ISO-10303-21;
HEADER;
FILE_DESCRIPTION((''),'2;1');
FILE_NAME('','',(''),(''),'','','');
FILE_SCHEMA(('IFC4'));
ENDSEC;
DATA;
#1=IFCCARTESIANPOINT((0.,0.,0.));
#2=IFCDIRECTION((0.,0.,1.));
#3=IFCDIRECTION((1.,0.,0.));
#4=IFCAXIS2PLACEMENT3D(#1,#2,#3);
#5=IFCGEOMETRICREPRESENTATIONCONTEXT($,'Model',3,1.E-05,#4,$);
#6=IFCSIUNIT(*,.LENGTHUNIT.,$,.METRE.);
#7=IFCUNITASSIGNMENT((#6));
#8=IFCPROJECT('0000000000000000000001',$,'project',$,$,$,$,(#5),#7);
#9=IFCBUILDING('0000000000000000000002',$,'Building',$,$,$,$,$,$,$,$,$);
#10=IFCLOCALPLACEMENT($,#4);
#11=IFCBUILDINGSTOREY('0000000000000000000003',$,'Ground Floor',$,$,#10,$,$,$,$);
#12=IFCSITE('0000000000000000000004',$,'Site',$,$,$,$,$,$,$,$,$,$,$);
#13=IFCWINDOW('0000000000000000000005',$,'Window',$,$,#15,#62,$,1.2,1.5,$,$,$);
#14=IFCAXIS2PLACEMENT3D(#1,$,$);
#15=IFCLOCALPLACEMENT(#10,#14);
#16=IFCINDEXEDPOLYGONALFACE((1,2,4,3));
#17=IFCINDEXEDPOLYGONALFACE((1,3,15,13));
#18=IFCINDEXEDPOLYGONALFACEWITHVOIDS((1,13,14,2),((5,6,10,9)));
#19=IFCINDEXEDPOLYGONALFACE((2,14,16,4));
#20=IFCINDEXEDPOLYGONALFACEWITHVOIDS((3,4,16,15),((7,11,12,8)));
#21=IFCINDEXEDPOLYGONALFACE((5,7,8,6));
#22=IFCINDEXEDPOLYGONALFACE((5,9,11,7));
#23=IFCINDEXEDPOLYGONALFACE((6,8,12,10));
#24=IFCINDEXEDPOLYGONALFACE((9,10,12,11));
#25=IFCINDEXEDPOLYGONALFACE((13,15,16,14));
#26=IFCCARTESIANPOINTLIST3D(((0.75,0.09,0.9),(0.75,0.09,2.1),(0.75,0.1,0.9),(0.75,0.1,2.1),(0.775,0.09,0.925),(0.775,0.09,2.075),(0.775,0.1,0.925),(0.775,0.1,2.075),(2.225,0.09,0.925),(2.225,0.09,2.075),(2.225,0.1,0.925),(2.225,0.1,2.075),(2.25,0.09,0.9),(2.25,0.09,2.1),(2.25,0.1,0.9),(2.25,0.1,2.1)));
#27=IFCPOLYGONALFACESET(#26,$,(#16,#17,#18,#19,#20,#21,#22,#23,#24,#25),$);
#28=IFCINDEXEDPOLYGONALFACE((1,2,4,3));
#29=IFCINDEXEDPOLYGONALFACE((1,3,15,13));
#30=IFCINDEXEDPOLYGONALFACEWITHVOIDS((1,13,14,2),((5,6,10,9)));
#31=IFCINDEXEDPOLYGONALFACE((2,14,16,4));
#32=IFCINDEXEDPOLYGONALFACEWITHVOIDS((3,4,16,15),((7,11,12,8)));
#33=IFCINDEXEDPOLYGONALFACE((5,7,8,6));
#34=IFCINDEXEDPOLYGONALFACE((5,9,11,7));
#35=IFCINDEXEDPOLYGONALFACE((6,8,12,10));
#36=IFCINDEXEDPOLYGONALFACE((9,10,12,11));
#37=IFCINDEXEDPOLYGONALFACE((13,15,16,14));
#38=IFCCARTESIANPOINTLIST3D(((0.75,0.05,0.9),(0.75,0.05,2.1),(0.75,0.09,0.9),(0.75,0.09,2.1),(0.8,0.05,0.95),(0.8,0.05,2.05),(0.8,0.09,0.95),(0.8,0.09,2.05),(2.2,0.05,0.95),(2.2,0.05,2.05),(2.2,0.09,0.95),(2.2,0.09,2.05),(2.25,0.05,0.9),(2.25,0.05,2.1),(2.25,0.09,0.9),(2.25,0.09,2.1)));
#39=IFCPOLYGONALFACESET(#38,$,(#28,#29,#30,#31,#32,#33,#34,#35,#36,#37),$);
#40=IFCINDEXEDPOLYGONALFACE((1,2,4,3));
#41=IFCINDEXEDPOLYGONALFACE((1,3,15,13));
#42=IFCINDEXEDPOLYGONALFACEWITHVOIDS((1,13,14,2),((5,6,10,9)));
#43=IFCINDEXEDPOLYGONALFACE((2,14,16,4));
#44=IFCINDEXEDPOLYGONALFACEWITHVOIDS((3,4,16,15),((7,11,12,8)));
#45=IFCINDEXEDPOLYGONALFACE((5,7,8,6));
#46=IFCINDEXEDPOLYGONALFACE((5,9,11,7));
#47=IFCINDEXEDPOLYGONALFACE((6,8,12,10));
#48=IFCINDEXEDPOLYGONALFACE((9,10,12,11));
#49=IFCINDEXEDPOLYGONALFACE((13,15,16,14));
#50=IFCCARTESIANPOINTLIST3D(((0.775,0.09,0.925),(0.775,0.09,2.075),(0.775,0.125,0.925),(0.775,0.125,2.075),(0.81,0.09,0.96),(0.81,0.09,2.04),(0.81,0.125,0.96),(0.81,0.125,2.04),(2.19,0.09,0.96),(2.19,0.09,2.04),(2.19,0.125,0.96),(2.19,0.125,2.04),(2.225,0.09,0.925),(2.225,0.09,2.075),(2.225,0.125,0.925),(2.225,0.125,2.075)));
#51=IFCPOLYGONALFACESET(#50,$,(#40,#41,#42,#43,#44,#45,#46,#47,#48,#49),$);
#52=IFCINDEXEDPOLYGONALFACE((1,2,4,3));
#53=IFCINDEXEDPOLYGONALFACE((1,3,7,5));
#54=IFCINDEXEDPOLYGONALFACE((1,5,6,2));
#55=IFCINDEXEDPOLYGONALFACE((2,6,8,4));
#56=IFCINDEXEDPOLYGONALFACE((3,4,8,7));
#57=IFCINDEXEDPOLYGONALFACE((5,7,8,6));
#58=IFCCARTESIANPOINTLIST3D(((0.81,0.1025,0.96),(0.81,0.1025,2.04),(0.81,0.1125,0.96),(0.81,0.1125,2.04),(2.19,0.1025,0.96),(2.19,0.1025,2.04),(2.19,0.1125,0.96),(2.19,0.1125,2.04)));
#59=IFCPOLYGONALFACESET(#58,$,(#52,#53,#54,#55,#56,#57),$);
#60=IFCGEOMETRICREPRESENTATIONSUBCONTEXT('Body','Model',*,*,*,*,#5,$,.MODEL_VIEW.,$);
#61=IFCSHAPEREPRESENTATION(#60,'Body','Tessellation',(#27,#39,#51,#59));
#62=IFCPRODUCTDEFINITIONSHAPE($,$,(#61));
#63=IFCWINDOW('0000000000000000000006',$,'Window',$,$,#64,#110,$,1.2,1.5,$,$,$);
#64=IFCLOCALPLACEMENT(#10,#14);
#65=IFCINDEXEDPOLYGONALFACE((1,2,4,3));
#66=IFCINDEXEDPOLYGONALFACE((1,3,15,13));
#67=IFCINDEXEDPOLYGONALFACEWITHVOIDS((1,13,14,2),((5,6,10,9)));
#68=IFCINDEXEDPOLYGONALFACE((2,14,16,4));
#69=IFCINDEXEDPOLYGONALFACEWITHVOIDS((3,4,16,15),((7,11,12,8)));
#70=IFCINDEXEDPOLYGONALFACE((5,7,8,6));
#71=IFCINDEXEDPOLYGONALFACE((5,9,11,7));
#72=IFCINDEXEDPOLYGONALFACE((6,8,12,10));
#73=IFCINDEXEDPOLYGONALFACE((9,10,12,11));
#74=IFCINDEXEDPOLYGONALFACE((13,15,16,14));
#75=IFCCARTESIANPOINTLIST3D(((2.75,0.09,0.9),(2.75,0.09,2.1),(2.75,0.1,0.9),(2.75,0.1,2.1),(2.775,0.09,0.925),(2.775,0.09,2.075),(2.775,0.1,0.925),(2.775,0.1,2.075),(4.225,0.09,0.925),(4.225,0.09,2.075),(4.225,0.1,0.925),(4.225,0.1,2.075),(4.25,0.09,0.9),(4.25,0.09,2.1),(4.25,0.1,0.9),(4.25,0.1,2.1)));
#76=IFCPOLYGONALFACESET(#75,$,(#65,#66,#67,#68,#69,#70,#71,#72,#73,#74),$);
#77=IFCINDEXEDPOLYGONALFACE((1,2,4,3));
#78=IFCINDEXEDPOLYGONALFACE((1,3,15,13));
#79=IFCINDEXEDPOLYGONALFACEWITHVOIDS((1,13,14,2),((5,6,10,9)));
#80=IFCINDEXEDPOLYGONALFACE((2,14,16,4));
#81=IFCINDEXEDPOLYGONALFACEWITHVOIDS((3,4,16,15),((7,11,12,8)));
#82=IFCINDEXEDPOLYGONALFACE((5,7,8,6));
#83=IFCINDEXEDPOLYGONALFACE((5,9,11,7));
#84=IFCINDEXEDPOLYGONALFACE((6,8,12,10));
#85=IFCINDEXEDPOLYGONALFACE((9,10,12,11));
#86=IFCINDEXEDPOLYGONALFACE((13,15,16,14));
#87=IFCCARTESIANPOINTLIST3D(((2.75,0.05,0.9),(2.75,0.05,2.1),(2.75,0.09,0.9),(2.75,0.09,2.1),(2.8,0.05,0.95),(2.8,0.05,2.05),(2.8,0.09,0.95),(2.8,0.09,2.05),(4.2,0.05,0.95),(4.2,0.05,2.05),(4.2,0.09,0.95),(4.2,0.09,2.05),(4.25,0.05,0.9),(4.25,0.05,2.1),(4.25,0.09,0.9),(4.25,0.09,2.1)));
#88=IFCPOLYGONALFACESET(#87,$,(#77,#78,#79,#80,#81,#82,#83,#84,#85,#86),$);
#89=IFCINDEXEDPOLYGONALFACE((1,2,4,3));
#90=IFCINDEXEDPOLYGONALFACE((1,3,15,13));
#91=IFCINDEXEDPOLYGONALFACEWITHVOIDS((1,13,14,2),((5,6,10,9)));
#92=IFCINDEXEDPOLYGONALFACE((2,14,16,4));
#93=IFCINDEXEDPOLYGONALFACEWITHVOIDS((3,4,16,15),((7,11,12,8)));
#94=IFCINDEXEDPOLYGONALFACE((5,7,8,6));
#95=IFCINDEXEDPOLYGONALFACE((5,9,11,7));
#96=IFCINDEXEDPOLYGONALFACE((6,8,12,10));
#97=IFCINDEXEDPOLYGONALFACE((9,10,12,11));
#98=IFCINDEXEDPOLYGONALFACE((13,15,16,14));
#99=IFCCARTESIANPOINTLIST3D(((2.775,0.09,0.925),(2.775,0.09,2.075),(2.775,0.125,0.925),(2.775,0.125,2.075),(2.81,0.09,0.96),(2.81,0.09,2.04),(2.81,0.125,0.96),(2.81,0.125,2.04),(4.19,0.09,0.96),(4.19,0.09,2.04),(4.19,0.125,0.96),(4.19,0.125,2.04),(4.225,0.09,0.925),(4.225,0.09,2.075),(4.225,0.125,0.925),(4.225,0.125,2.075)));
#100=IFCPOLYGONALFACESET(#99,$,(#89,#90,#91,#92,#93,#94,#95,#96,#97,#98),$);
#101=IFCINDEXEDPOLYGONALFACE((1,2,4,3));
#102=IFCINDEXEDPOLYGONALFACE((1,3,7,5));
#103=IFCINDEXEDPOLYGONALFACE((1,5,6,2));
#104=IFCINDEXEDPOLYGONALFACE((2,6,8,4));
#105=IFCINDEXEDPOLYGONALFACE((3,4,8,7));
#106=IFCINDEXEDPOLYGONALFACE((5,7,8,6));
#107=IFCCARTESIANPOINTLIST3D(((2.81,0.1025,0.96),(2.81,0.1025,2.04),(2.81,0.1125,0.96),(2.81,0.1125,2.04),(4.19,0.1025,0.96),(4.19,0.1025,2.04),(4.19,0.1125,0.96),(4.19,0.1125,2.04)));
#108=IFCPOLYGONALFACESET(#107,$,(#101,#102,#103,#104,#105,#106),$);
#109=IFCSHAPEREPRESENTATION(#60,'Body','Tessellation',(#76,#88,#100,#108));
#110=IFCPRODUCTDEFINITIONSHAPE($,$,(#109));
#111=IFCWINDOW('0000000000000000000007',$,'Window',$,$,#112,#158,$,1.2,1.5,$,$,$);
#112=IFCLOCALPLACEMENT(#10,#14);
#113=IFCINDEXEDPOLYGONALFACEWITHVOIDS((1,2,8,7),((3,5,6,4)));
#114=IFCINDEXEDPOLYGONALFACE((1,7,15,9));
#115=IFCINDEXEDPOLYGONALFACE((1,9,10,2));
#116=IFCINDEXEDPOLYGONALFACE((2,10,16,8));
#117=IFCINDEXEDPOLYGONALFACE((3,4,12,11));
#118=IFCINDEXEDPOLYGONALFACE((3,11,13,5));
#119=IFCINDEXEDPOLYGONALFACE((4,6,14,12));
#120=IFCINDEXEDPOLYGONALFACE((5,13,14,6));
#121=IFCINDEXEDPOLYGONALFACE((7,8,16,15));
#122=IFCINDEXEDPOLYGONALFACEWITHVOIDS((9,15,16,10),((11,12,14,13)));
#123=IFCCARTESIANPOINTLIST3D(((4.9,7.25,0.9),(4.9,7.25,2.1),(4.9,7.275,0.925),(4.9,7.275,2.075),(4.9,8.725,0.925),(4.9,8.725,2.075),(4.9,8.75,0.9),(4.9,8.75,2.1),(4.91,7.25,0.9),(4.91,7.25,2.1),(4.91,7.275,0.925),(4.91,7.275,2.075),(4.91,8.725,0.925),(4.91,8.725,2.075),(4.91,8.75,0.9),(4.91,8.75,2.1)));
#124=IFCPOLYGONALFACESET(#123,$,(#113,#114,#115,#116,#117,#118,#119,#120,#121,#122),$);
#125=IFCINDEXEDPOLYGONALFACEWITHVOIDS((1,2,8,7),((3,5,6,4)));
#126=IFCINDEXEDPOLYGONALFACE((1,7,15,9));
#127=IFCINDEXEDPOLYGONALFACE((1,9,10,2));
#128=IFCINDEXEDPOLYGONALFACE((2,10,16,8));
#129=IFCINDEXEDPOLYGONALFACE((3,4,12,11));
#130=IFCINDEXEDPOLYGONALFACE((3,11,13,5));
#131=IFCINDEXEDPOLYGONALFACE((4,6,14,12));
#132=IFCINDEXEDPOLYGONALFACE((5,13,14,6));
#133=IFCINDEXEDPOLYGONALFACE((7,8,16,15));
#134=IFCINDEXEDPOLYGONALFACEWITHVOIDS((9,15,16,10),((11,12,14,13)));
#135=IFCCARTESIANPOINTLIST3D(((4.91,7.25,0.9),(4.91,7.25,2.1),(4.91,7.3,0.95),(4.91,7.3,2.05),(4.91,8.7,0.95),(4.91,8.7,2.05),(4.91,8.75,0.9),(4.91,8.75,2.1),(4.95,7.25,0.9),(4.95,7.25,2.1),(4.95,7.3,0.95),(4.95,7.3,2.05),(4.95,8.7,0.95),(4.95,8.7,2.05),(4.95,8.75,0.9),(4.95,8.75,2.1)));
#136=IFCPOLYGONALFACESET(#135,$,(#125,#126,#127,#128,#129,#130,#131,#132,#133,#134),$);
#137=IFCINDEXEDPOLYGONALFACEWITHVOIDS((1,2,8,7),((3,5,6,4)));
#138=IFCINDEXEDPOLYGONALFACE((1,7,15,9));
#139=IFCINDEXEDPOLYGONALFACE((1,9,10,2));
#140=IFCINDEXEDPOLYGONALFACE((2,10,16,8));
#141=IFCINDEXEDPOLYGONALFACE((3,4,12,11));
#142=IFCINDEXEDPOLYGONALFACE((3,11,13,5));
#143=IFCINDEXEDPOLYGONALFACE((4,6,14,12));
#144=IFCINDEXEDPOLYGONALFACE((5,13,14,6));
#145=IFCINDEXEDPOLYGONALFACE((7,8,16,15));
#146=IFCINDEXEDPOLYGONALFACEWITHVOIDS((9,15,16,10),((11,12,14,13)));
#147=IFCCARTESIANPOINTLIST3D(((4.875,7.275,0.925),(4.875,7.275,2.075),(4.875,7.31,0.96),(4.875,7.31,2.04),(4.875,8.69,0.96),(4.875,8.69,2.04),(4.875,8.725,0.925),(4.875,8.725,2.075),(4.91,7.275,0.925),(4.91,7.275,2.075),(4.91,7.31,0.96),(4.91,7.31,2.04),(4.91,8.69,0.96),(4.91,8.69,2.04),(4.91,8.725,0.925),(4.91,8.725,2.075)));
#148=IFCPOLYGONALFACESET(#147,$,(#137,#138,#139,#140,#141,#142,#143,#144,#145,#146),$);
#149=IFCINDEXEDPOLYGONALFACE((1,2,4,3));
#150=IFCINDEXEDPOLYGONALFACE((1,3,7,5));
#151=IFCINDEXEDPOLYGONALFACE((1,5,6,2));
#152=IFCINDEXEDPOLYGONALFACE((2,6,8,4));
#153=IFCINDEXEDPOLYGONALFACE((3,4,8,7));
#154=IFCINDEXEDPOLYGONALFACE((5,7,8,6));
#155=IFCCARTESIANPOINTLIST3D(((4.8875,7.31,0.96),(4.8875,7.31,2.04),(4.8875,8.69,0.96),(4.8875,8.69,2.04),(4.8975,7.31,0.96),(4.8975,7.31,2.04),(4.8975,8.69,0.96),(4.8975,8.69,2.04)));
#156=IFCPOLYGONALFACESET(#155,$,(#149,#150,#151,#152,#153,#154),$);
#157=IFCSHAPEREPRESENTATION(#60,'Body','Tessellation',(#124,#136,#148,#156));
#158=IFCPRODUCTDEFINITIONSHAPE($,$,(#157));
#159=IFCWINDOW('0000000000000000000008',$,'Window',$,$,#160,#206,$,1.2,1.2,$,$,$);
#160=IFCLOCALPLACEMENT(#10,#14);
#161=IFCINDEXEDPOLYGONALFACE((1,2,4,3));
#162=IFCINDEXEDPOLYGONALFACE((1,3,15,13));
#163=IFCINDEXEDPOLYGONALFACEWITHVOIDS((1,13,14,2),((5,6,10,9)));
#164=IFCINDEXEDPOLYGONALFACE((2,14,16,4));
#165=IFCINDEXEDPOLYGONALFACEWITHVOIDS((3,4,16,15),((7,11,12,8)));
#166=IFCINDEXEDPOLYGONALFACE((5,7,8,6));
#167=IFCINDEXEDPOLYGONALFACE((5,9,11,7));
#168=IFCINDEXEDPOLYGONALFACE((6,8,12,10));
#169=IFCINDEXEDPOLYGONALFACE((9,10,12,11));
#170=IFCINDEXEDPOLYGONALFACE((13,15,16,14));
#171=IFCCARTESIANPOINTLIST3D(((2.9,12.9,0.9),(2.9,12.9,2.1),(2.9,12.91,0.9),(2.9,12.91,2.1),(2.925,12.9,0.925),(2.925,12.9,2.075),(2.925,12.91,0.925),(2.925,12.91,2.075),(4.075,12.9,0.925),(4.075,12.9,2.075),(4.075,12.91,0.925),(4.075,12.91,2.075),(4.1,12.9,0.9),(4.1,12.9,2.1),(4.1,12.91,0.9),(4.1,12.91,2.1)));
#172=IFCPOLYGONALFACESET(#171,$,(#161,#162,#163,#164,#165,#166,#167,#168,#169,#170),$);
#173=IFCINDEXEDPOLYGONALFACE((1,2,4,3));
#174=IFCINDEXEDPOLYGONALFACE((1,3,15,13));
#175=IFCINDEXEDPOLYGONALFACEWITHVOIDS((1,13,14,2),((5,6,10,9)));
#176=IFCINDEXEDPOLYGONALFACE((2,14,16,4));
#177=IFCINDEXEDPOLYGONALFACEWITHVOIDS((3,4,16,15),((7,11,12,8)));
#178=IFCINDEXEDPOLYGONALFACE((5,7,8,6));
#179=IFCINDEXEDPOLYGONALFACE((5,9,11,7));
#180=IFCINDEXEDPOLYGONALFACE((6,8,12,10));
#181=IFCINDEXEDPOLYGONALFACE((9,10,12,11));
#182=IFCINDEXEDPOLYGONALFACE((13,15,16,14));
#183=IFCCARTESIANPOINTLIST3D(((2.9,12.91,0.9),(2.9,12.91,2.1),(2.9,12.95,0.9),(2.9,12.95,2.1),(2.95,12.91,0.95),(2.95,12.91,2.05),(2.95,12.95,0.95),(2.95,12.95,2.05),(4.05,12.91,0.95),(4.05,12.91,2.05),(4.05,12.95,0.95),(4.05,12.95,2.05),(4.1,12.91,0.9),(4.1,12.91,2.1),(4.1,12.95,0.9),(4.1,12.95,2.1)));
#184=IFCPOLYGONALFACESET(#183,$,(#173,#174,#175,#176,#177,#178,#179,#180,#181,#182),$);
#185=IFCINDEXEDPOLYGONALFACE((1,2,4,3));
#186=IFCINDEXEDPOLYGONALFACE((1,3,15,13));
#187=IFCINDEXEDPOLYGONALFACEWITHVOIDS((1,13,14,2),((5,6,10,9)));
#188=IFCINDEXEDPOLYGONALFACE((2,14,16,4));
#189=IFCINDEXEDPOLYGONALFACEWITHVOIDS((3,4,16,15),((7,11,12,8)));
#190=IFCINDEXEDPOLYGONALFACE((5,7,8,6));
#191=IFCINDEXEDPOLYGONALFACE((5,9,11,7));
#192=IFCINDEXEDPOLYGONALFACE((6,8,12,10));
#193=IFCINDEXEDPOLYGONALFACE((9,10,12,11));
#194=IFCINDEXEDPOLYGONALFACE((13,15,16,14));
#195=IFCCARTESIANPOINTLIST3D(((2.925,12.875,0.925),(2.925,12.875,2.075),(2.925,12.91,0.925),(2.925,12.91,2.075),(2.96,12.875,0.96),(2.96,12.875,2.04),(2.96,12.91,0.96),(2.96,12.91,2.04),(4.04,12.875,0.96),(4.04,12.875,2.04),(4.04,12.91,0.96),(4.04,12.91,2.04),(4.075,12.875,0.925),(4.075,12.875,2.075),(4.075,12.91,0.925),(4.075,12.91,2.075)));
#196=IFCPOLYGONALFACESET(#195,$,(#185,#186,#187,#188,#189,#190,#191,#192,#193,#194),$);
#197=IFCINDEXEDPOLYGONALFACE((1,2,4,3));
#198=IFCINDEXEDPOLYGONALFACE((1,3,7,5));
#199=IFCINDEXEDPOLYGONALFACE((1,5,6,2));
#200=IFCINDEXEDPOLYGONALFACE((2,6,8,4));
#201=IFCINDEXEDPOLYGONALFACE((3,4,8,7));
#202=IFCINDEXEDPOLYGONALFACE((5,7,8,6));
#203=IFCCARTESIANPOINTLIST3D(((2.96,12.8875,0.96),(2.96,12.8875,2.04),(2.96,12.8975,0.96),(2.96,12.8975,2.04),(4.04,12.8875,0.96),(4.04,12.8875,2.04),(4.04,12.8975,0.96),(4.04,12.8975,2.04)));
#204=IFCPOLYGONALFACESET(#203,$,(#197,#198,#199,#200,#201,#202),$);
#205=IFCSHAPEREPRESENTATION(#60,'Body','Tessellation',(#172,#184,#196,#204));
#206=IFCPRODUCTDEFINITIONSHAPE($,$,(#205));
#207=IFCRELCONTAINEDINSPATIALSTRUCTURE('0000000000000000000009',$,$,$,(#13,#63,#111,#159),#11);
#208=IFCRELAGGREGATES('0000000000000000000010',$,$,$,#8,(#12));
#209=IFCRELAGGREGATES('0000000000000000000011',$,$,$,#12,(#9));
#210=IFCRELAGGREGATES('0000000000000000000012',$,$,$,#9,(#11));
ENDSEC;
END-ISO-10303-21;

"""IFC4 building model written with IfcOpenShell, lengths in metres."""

from ifc_helpers import new_model, si_unit, frame, origin_with_axes, place, context, subcontext, project, spatial, line, indexed_curve, outline, extrude, element, save


model = new_model("IFC4")

# Units and contexts
model_context = context("Model", 3, precision=1e-05, world=origin_with_axes())
body_context = subcontext(model_context, "Body", "Model", "MODEL_VIEW")
ifc_project = project(units=[si_unit("LENGTHUNIT", "METRE")], contexts=[model_context])

# Site, building, storey
site = spatial("IfcSite", under=ifc_project, Name="Site")
building = spatial("IfcBuilding", under=site, Name="Building")
storey_placement = place(None, origin_with_axes())
storey = spatial("IfcBuildingStorey", under=building, at=storey_placement, Name="Ground Floor")

# Windows
for number, where, z_axis, x_axis, name in (
    (1, (0.75, 0.0, 0.9), (0.0, 0.0, 1.0), (1.0, 0.0, 0.0), "Window"),
    (2, (2.75, 0.0, 0.9), (0.0, 0.0, 1.0), (1.0, 0.0, 0.0), "Window"),
    (3, (5.0, 7.25, 0.9), (0.0, 0.0, 1.0), (0.0, 1.0, 0.0), "Window"),
):
    element("IfcWindow", number, at=place(storey_placement, frame(where, z_axis=z_axis, x_axis=x_axis)), inside=storey, Name=name, OverallHeight=1.2, OverallWidth=1.5, context=body_context, shape_type="SweptSolid", body=[
        extrude(outline(indexed_curve([(0.0, 0.0), (1.5, 0.0), (1.5, 1.2), (0.0, 1.2)], segments=[line(1, 2, 3, 4, 1)]), holes=[indexed_curve([(0.025, 0.025), (1.475, 0.025), (1.475, 1.175), (0.025, 1.175)], segments=[line(1, 2, 3, 4, 1)])]), frame((0.0, 0.09, 0.0), z_axis=(0.0, -1.0, 0.0), x_axis=(1.0, 0.0, 0.0)), (0.0, 0.0, -1.0), 0.01),
        extrude(outline(indexed_curve([(0.0, 0.0), (1.5, 0.0), (1.5, 1.2), (0.0, 1.2)], segments=[line(1, 2, 3, 4, 1)]), holes=[indexed_curve([(0.05, 0.05), (1.45, 0.05), (1.45, 1.15), (0.05, 1.15)], segments=[line(1, 2, 3, 4, 1)])]), frame((0.0, 0.05, 0.0), z_axis=(0.0, -1.0, 0.0), x_axis=(1.0, 0.0, 0.0)), (0.0, 0.0, -1.0), 0.04),
        extrude(outline(indexed_curve([(0.0, 0.0), (1.45, 0.0), (1.45, 1.15), (0.0, 1.15)], segments=[line(1, 2, 3, 4, 1)]), holes=[indexed_curve([(0.035, 0.035), (1.415, 0.035), (1.415, 1.115), (0.035, 1.115)], segments=[line(1, 2, 3, 4, 1)])]), frame((0.025, 0.09, 0.025), z_axis=(0.0, -1.0, 0.0), x_axis=(1.0, 0.0, 0.0)), (0.0, 0.0, -1.0), 0.035),
        extrude(outline(indexed_curve([(0.035, 0.035), (1.415, 0.035), (1.415, 1.115), (0.035, 1.115)], segments=[line(1, 2, 3, 4, 1)])), frame((0.025, 0.1025, 0.025), z_axis=(0.0, -1.0, 0.0), x_axis=(1.0, 0.0, 0.0)), (0.0, 0.0, -1.0), 0.01),
    ])
window_1_placement = place(storey_placement, frame((4.1, 13.0, 0.9), z_axis=(0.0, 0.0, 1.0), x_axis=(-1.0, 0.0, 0.0)))
element("IfcWindow", 4, at=window_1_placement, inside=storey, Name="Window", OverallHeight=1.2, OverallWidth=1.2, context=body_context, shape_type="SweptSolid", body=[
    extrude(outline(indexed_curve([(0.0, 0.0), (1.2, 0.0), (1.2, 1.2), (0.0, 1.2)], segments=[line(1, 2, 3, 4, 1)]), holes=[indexed_curve([(0.025, 0.025), (1.175, 0.025), (1.175, 1.175), (0.025, 1.175)], segments=[line(1, 2, 3, 4, 1)])]), frame((0.0, 0.09, 0.0), z_axis=(0.0, -1.0, 0.0), x_axis=(1.0, 0.0, 0.0)), (0.0, 0.0, -1.0), 0.01),
    extrude(outline(indexed_curve([(0.0, 0.0), (1.2, 0.0), (1.2, 1.2), (0.0, 1.2)], segments=[line(1, 2, 3, 4, 1)]), holes=[indexed_curve([(0.05, 0.05), (1.15, 0.05), (1.15, 1.15), (0.05, 1.15)], segments=[line(1, 2, 3, 4, 1)])]), frame((0.0, 0.05, 0.0), z_axis=(0.0, -1.0, 0.0), x_axis=(1.0, 0.0, 0.0)), (0.0, 0.0, -1.0), 0.04),
    extrude(outline(indexed_curve([(0.0, 0.0), (1.15, 0.0), (1.15, 1.15), (0.0, 1.15)], segments=[line(1, 2, 3, 4, 1)]), holes=[indexed_curve([(0.035, 0.035), (1.115, 0.035), (1.115, 1.115), (0.035, 1.115)], segments=[line(1, 2, 3, 4, 1)])]), frame((0.025, 0.09, 0.025), z_axis=(0.0, -1.0, 0.0), x_axis=(1.0, 0.0, 0.0)), (0.0, 0.0, -1.0), 0.035),
    extrude(outline(indexed_curve([(0.035, 0.035), (1.115, 0.035), (1.115, 1.115), (0.035, 1.115)], segments=[line(1, 2, 3, 4, 1)])), frame((0.025, 0.1025, 0.025), z_axis=(0.0, -1.0, 0.0), x_axis=(1.0, 0.0, 0.0)), (0.0, 0.0, -1.0), 0.01),
])

save(model, "model.ifc")
